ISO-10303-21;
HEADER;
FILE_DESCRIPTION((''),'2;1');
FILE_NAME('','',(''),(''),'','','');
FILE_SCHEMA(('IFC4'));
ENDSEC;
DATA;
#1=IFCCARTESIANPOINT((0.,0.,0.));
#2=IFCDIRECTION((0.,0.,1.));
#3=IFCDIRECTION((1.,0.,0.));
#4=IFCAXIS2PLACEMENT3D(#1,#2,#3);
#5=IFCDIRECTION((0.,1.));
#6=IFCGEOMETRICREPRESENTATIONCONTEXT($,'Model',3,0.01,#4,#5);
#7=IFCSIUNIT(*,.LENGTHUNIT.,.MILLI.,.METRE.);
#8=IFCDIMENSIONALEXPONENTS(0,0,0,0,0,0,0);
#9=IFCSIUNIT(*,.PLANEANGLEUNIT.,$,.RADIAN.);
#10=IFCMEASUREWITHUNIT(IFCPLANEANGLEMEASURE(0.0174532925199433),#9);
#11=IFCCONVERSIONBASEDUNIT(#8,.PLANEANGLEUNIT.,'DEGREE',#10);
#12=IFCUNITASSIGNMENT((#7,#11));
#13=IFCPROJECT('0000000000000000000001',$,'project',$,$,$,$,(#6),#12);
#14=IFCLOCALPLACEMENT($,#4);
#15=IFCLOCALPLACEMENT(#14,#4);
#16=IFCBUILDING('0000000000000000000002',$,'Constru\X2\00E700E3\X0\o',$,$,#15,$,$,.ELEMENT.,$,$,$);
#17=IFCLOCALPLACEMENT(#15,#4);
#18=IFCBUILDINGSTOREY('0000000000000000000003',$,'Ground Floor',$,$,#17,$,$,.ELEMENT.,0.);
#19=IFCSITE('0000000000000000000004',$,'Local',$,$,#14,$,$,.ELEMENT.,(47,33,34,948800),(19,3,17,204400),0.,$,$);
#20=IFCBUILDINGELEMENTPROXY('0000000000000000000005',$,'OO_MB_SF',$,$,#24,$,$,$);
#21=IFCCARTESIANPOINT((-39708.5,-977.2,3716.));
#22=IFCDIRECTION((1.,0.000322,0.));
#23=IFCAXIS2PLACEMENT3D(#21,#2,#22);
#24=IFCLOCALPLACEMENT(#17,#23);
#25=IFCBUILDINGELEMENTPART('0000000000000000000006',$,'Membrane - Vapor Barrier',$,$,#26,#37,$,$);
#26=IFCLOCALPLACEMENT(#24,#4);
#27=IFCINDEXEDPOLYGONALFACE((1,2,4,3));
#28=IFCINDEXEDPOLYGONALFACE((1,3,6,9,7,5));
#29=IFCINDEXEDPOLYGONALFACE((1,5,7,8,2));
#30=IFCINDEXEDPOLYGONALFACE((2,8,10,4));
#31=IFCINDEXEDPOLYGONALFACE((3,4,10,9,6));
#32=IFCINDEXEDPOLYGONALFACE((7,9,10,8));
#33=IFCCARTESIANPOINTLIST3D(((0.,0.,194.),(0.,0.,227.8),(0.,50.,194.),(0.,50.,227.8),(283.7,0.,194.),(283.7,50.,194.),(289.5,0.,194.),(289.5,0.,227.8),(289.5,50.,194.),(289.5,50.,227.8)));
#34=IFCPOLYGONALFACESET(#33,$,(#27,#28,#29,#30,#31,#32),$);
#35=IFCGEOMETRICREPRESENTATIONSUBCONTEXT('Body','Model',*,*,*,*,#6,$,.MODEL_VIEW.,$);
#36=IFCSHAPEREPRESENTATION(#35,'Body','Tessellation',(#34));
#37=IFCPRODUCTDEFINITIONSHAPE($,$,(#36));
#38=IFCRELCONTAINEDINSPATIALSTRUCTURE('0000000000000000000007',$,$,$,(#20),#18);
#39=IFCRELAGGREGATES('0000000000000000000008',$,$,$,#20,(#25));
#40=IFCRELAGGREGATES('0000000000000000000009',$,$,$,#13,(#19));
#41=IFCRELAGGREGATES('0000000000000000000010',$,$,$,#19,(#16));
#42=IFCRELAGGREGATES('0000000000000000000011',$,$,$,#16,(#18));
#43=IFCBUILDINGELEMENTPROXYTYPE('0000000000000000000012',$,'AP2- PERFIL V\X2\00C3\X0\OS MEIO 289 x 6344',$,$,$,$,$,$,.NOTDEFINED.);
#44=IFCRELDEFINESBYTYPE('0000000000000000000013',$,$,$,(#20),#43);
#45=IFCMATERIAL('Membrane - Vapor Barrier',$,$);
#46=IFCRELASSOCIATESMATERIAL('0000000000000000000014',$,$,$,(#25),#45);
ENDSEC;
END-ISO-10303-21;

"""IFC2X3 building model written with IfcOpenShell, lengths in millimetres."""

from ifc_helpers import new_model, entity, si_unit, converted_unit, direction, frame, origin_with_axes, place, context, subcontext, project, spatial, polyline, outline, extrude, material, type_object, element, aggregate, save


model = new_model("IFC2X3")

# Units and contexts
model_context = context("Model", 3, precision=0.01, world=origin_with_axes(), true_north=direction((0.0, 1.0)))
body_context = subcontext(model_context, "Body", "Model", "MODEL_VIEW")
ifc_project = project(units=[si_unit("LENGTHUNIT", "METRE", prefix="MILLI"), converted_unit("PLANEANGLEUNIT", "DEGREE", entity("IfcPlaneAngleMeasure", 0.0174532925199433), si_unit("PLANEANGLEUNIT", "RADIAN"), dimensions=[0, 0, 0, 0, 0, 0, 0])], contexts=[model_context])

# Site, building, storey
site_placement = place(None, origin_with_axes())
site = spatial("IfcSite", under=ifc_project, at=site_placement, Name="Local", CompositionType="ELEMENT", RefLatitude=(47, 33, 34, 948800), RefLongitude=(19, 3, 17, 204400), RefElevation=0.0)
building_placement = place(site_placement, origin_with_axes())
building = spatial("IfcBuilding", under=site, at=building_placement, Name="Construção", CompositionType="ELEMENT")
storey_placement = place(building_placement, origin_with_axes())
storey = spatial("IfcBuildingStorey", under=building, at=storey_placement, Name="Ground Floor", CompositionType="ELEMENT", Elevation=0.0)

# Shared definitions
building_element_proxy_type = type_object("IfcBuildingElementProxyType", Name="AP2- PERFIL VÃOS MEIO 289 x 6344", PredefinedType="NOTDEFINED")
ifc_material_1 = material(Name="Membrane - Vapor Barrier")

# Building element proxy, building element part
proxy_1_placement = place(storey_placement, frame((-39708.5, -977.2, 3716.0), z_axis=(0.0, 0.0, 1.0), x_axis=(1.0, 0.000322, 0.0)))
proxy_1 = element("IfcBuildingElementProxy", 1, at=proxy_1_placement, inside=storey, type_object=building_element_proxy_type, Name="OO_MB_SF")
building_element_part_1_placement = place(proxy_1_placement, origin_with_axes())
building_element_part_1 = element("IfcBuildingElementPart", 2, at=building_element_part_1_placement, material=ifc_material_1, Name="Membrane - Vapor Barrier", context=body_context, shape_type="SweptSolid", body=[
    extrude(outline(polyline([(0.0, 194.0), (283.7, 194.0), (289.5, 194.0), (289.5, 227.8), (0.0, 227.8), (0.0, 194.0)])), frame((0.0, 50.0, 0.0), z_axis=(0.0, -1.0, 0.0), x_axis=(1.0, 0.0, 0.0)), (0.0, 0.0, 1.0), 50.0),
])
aggregate(proxy_1, [building_element_part_1])

save(model, "model.ifc")
